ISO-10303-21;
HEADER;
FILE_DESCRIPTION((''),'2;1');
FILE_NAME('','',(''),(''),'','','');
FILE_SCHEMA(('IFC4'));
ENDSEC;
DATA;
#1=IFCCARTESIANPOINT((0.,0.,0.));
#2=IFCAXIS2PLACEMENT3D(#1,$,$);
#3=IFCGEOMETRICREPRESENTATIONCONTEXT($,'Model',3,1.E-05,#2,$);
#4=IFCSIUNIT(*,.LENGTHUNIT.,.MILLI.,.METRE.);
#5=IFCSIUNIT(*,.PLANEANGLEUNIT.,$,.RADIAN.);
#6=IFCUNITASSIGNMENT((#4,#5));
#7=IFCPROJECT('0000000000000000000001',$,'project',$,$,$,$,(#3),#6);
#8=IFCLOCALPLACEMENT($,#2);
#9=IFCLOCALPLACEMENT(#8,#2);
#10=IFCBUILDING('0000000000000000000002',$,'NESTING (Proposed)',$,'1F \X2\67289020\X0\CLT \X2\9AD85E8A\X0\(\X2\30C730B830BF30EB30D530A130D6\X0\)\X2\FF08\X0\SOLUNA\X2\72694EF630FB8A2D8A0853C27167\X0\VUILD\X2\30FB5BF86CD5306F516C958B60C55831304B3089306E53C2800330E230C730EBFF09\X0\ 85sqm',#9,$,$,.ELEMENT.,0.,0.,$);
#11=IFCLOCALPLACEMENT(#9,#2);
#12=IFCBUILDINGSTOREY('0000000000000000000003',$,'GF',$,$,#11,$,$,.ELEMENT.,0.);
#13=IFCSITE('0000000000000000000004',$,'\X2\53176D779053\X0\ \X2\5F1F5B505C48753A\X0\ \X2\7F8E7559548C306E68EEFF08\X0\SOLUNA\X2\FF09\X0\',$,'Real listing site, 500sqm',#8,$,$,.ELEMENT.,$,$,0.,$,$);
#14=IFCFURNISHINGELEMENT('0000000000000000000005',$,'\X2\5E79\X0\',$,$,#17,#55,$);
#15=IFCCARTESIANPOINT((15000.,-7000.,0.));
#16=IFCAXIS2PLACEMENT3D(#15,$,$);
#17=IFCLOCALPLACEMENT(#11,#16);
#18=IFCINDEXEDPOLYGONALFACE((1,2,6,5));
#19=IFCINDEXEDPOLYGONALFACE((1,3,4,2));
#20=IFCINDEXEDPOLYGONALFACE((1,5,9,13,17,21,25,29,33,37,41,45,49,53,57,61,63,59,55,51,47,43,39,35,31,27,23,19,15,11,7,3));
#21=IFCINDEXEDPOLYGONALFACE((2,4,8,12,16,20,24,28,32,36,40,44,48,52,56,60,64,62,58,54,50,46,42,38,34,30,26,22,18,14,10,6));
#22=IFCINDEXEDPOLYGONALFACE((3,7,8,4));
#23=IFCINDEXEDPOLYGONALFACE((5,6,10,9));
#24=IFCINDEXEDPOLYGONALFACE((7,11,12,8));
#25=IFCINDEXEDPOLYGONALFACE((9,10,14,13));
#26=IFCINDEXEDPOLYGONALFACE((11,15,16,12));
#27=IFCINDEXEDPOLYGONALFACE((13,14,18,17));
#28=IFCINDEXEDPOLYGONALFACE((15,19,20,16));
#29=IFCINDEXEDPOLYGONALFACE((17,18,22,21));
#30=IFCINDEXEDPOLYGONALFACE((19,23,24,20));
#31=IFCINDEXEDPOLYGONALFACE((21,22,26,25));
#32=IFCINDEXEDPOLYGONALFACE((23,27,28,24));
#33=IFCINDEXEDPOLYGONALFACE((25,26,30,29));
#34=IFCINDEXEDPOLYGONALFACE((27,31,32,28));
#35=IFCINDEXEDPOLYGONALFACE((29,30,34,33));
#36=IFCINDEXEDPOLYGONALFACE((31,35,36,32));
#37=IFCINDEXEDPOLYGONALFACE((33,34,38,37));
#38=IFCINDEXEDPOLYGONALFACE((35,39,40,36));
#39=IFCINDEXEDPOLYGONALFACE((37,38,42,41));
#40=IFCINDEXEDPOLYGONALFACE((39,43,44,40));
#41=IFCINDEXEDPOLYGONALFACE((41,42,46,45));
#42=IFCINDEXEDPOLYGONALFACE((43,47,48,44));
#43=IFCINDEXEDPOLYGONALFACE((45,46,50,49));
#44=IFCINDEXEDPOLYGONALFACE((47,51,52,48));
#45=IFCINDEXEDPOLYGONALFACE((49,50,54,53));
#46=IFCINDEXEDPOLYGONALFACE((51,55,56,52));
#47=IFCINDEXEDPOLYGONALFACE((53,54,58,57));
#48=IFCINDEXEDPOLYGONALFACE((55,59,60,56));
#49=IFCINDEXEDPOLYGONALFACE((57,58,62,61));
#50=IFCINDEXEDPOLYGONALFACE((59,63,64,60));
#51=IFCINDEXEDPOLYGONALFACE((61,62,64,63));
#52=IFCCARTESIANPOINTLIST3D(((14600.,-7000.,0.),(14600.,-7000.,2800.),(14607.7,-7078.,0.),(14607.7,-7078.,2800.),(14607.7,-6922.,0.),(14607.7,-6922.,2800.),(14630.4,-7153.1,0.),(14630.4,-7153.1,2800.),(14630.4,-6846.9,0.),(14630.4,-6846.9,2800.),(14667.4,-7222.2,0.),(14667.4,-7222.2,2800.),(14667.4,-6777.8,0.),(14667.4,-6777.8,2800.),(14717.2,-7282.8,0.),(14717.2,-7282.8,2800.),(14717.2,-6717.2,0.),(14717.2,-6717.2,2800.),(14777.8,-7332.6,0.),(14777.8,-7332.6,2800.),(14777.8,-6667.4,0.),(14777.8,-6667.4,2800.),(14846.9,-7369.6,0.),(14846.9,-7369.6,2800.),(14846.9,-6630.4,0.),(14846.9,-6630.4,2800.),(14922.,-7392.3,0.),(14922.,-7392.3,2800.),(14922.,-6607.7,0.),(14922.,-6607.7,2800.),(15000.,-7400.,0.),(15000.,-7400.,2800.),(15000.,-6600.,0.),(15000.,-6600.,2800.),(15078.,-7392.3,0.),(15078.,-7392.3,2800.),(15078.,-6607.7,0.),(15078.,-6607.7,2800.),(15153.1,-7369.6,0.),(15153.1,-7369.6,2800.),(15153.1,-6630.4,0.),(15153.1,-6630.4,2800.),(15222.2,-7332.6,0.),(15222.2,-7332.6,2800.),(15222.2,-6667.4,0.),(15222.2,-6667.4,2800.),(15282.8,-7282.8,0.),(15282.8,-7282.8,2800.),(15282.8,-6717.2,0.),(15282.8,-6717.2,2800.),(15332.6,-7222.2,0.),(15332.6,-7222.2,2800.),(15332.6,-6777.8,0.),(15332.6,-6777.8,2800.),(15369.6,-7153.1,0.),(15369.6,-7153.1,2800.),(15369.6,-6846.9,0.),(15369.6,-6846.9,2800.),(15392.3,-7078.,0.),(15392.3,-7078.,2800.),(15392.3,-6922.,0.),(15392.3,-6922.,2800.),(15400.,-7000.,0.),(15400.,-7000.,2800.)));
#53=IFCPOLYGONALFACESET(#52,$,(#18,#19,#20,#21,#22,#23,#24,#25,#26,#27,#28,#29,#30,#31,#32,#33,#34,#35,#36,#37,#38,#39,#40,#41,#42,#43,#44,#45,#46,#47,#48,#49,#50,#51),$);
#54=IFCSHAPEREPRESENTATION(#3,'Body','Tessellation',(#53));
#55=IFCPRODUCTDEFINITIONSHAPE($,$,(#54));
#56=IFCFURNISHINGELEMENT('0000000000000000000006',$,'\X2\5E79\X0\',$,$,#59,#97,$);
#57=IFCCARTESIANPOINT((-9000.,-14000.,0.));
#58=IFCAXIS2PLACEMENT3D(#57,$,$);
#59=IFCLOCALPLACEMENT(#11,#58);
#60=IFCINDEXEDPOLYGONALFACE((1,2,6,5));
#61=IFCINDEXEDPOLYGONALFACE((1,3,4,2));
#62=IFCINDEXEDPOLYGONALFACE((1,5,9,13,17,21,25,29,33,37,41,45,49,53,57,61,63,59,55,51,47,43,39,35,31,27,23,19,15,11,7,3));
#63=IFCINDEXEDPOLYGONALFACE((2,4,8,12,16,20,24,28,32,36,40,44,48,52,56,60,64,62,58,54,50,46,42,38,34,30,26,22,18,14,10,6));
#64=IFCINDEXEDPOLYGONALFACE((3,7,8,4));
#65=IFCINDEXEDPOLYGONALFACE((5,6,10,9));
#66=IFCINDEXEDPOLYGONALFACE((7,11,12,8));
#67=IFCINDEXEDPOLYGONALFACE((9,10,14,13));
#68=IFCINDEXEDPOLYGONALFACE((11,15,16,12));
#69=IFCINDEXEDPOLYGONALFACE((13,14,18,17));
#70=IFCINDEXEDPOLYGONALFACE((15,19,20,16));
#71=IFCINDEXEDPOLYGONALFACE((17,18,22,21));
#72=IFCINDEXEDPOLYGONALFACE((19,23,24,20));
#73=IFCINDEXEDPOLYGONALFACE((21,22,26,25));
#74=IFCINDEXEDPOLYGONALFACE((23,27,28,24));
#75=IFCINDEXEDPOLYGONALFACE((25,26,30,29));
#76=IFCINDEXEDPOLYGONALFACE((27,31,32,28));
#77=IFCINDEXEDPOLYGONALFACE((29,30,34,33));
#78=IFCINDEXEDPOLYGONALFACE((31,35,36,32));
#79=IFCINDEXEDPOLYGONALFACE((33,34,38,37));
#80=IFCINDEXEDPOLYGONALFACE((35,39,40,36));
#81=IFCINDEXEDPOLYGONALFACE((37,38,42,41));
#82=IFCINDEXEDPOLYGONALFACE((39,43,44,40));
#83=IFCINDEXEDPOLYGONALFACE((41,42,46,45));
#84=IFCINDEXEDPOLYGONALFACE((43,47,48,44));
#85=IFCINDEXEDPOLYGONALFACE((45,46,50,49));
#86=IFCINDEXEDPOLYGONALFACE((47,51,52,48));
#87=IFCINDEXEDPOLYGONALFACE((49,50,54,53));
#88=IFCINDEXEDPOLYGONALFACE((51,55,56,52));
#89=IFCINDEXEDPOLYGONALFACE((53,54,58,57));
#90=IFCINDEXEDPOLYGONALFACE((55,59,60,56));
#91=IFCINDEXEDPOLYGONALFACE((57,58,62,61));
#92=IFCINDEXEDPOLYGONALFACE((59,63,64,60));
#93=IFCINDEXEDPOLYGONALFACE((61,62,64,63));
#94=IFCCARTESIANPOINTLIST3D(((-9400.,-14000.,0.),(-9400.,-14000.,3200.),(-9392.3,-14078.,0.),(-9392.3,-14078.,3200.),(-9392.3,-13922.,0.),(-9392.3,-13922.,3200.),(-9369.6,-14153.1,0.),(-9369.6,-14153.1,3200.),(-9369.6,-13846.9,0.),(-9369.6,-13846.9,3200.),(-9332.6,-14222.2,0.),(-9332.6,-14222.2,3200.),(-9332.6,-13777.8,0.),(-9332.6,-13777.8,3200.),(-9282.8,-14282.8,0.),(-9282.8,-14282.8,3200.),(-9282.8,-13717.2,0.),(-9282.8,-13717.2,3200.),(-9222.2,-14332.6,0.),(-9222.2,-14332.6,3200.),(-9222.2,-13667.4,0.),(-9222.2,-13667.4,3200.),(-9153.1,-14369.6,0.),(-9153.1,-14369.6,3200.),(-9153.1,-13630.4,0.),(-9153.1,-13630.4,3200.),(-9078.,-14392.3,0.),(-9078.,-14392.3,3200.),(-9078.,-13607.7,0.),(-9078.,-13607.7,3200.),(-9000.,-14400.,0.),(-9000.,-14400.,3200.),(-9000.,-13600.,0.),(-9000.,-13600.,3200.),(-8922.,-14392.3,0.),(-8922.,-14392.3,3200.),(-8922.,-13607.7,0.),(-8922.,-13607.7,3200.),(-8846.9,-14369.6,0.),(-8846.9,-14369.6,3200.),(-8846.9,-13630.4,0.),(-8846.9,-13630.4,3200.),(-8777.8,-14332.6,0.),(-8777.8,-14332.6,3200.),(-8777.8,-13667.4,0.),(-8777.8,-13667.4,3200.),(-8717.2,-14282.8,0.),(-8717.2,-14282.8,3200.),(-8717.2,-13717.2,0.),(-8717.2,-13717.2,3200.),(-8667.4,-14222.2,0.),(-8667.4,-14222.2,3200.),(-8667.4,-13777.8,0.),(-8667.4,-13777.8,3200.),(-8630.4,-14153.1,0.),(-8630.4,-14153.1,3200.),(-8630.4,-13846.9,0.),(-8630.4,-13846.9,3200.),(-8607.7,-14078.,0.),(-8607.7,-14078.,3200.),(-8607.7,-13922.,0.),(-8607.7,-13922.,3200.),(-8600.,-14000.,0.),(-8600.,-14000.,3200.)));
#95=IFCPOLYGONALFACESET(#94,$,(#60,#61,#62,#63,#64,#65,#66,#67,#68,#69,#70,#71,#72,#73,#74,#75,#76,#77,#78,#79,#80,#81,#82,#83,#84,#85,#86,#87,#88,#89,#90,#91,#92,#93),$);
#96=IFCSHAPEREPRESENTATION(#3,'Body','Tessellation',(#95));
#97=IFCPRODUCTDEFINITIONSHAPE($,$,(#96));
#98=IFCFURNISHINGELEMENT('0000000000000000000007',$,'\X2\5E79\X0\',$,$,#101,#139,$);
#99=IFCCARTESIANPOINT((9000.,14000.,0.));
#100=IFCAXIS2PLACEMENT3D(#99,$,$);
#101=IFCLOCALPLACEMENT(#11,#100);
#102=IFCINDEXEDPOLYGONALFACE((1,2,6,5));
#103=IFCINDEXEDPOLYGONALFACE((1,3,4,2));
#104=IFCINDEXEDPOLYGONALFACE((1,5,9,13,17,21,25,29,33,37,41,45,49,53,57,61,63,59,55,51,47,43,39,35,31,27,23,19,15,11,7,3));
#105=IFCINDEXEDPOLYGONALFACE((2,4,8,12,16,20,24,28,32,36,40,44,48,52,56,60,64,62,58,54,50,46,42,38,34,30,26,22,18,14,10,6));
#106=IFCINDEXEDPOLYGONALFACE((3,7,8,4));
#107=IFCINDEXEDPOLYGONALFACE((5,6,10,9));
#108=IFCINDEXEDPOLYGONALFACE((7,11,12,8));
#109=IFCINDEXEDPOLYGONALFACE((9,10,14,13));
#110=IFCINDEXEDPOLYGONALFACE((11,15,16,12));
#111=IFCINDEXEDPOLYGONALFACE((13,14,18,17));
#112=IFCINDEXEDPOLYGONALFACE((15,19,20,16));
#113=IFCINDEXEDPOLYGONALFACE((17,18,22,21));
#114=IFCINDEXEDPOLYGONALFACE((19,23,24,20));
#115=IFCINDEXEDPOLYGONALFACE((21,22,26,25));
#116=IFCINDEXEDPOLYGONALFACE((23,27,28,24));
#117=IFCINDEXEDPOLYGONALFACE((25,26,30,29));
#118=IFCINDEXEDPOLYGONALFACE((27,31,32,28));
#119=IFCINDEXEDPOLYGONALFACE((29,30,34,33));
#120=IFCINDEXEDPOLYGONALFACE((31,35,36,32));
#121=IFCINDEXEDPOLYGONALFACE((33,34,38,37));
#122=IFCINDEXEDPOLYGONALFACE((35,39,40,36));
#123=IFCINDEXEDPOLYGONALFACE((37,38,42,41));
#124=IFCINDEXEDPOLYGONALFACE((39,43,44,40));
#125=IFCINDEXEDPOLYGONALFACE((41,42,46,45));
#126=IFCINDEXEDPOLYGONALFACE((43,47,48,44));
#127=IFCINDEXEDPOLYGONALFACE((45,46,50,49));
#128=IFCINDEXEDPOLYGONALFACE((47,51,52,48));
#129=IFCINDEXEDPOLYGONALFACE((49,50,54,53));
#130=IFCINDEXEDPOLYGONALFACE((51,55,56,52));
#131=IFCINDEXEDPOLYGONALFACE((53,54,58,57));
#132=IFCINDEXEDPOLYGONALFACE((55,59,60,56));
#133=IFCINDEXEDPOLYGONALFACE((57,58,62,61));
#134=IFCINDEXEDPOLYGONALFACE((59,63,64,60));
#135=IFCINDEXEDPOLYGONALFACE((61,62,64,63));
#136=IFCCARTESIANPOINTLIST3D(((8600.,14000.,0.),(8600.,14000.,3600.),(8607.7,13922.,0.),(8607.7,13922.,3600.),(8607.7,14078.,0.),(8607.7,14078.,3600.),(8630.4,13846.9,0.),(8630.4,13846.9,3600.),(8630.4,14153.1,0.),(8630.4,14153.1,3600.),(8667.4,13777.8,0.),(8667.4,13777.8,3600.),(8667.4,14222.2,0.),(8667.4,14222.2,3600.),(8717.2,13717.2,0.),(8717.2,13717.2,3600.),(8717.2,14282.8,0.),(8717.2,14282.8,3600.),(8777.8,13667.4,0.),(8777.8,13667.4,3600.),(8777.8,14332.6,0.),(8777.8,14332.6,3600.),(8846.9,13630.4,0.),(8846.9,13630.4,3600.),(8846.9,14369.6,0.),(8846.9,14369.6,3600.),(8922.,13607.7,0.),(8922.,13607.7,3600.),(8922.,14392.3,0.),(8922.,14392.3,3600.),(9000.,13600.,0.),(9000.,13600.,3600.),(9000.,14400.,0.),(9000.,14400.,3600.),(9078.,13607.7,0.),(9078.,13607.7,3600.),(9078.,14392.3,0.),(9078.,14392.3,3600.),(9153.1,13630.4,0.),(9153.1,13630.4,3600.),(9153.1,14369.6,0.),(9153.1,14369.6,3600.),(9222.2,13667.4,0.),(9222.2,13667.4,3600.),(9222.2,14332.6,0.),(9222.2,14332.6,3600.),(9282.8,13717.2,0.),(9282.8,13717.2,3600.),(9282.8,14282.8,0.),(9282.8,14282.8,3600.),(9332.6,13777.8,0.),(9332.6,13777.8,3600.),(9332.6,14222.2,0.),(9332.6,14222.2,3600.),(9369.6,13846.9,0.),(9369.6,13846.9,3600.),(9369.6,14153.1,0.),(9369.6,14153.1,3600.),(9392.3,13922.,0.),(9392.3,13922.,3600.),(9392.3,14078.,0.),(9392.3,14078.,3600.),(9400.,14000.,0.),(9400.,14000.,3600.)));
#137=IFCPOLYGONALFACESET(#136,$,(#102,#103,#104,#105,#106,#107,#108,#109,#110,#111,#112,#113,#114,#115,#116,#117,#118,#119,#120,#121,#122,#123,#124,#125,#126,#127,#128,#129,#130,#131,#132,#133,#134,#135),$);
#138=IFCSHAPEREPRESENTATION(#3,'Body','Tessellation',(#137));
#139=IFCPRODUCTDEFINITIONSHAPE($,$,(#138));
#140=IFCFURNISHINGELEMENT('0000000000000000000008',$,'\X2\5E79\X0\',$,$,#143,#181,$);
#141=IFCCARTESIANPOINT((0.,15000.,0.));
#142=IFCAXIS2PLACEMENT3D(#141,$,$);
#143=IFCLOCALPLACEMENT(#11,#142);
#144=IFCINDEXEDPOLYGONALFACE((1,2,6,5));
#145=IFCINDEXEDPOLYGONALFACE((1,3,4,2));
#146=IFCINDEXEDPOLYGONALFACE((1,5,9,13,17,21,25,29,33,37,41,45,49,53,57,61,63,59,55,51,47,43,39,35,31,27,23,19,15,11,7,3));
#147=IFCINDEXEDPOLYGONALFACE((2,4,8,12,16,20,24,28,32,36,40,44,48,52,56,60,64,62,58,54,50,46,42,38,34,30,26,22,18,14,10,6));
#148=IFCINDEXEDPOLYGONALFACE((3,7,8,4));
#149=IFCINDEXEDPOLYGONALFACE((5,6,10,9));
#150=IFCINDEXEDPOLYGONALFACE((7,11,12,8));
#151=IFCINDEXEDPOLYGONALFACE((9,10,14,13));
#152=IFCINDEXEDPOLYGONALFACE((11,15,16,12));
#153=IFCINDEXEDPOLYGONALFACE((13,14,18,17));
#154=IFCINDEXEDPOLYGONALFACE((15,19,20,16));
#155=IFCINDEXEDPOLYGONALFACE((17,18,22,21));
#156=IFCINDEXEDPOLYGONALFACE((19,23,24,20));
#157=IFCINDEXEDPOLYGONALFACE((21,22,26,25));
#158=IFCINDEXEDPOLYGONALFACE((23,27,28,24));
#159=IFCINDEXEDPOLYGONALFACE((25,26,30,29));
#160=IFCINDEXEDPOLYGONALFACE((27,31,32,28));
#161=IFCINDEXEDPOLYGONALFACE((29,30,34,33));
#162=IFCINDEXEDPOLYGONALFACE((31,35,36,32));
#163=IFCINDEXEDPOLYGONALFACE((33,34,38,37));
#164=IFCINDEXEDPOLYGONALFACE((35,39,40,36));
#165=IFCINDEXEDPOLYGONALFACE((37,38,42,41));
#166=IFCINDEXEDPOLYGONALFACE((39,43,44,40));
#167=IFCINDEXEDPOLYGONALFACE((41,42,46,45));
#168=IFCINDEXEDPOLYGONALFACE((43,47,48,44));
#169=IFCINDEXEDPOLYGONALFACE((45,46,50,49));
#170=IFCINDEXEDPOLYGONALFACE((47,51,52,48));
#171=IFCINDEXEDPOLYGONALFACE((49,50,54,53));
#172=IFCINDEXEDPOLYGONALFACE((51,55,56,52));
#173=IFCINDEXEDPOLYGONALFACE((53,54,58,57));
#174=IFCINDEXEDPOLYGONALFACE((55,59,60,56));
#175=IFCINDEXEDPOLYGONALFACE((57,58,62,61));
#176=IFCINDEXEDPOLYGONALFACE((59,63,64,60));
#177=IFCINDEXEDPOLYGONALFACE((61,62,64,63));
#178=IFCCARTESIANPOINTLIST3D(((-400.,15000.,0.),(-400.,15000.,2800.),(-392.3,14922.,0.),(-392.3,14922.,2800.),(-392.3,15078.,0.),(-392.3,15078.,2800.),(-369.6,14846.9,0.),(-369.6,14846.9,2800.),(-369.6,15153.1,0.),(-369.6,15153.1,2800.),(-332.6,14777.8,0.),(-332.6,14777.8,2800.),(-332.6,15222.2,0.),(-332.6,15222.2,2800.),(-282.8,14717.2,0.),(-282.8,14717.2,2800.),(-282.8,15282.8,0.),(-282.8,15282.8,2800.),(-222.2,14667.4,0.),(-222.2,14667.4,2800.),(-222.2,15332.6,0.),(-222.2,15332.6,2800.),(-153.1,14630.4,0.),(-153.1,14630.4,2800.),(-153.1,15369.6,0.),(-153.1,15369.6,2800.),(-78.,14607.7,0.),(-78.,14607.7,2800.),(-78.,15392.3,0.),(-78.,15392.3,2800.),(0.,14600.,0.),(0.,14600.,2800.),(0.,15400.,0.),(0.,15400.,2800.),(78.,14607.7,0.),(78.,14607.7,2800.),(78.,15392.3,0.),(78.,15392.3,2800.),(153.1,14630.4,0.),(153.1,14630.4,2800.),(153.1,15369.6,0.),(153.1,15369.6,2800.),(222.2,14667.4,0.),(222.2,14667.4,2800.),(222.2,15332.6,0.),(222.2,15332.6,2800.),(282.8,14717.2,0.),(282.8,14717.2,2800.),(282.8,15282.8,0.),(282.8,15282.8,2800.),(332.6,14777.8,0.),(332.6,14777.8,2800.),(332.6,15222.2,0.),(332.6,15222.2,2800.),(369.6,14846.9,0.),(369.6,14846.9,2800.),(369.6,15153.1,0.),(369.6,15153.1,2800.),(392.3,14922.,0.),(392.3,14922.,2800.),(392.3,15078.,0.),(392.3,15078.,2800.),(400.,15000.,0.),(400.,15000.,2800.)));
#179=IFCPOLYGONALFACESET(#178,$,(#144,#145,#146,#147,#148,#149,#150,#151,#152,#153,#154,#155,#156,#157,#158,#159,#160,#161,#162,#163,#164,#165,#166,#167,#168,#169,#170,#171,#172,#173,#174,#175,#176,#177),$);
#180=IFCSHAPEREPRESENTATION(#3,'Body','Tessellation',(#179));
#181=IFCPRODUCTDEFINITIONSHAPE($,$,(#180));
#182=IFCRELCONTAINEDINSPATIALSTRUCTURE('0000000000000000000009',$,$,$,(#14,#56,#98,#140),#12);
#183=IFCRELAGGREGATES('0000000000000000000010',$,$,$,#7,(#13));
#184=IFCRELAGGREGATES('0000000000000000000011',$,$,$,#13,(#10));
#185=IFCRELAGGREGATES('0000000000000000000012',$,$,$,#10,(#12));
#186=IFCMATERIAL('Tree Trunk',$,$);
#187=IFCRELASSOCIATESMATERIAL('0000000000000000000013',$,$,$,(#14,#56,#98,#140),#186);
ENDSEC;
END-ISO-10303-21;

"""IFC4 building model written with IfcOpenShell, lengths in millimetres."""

from ifc_helpers import new_model, si_unit, frame, origin, origin_2d, place, context, project, spatial, circle, extrude, material, element, save


model = new_model("IFC4")

# Units and contexts
model_context = context("Model", 3, precision=1e-05, world=origin())
ifc_project = project(units=[si_unit("LENGTHUNIT", "METRE", prefix="MILLI"), si_unit("PLANEANGLEUNIT", "RADIAN")], contexts=[model_context])

# Site, building, storey
site_placement = place(None, origin())
site = spatial("IfcSite", under=ifc_project, at=site_placement, Name="北海道 弟子屈町 美留和の森（SOLUNA）", ObjectType="Real listing site, 500sqm", CompositionType="ELEMENT", RefElevation=0.0)
building_placement = place(site_placement, origin())
building = spatial("IfcBuilding", under=site, at=building_placement, Name="NESTING (Proposed)", ObjectType="1F 木造CLT 高床(デジタルファブ)（SOLUNA物件・設計参照VUILD・寸法は公開情報からの参考モデル） 85sqm", CompositionType="ELEMENT", ElevationOfRefHeight=0.0, ElevationOfTerrain=0.0)
storey_placement = place(building_placement, origin())
storey = spatial("IfcBuildingStorey", under=building, at=storey_placement, Name="GF", CompositionType="ELEMENT", Elevation=0.0)

# Furnishing elements
ifc_material_1 = material(Name="Tree Trunk")
furnishing_1_placement = place(storey_placement, frame((15000.0, -7000.0, 0.0)))
element("IfcFurnishingElement", 1, at=furnishing_1_placement, inside=storey, material=ifc_material_1, Name="幹", context=model_context, shape_type="SweptSolid", body=[
    extrude(circle(Radius=400.0, at=origin_2d()), frame((15000.0, -7000.0, 0.0)), (0.0, 0.0, 1.0), 2800.0),
])
furnishing_2_placement = place(storey_placement, frame((-9000.0, -14000.0, 0.0)))
element("IfcFurnishingElement", 2, at=furnishing_2_placement, inside=storey, material=ifc_material_1, Name="幹", context=model_context, shape_type="SweptSolid", body=[
    extrude(circle(Radius=400.0, at=origin_2d()), frame((-9000.0, -14000.0, 0.0)), (0.0, 0.0, 1.0), 3200.0),
])
furnishing_3_placement = place(storey_placement, frame((9000.0, 14000.0, 0.0)))
element("IfcFurnishingElement", 3, at=furnishing_3_placement, inside=storey, material=ifc_material_1, Name="幹", context=model_context, shape_type="SweptSolid", body=[
    extrude(circle(Radius=400.0, at=origin_2d()), frame((9000.0, 14000.0, 0.0)), (0.0, 0.0, 1.0), 3600.0),
])
furnishing_4_placement = place(storey_placement, frame((0.0, 15000.0, 0.0)))
element("IfcFurnishingElement", 4, at=furnishing_4_placement, inside=storey, material=ifc_material_1, Name="幹", context=model_context, shape_type="SweptSolid", body=[
    extrude(circle(Radius=400.0, at=origin_2d()), frame((0.0, 15000.0, 0.0)), (0.0, 0.0, 1.0), 2800.0),
])

save(model, "model.ifc")
